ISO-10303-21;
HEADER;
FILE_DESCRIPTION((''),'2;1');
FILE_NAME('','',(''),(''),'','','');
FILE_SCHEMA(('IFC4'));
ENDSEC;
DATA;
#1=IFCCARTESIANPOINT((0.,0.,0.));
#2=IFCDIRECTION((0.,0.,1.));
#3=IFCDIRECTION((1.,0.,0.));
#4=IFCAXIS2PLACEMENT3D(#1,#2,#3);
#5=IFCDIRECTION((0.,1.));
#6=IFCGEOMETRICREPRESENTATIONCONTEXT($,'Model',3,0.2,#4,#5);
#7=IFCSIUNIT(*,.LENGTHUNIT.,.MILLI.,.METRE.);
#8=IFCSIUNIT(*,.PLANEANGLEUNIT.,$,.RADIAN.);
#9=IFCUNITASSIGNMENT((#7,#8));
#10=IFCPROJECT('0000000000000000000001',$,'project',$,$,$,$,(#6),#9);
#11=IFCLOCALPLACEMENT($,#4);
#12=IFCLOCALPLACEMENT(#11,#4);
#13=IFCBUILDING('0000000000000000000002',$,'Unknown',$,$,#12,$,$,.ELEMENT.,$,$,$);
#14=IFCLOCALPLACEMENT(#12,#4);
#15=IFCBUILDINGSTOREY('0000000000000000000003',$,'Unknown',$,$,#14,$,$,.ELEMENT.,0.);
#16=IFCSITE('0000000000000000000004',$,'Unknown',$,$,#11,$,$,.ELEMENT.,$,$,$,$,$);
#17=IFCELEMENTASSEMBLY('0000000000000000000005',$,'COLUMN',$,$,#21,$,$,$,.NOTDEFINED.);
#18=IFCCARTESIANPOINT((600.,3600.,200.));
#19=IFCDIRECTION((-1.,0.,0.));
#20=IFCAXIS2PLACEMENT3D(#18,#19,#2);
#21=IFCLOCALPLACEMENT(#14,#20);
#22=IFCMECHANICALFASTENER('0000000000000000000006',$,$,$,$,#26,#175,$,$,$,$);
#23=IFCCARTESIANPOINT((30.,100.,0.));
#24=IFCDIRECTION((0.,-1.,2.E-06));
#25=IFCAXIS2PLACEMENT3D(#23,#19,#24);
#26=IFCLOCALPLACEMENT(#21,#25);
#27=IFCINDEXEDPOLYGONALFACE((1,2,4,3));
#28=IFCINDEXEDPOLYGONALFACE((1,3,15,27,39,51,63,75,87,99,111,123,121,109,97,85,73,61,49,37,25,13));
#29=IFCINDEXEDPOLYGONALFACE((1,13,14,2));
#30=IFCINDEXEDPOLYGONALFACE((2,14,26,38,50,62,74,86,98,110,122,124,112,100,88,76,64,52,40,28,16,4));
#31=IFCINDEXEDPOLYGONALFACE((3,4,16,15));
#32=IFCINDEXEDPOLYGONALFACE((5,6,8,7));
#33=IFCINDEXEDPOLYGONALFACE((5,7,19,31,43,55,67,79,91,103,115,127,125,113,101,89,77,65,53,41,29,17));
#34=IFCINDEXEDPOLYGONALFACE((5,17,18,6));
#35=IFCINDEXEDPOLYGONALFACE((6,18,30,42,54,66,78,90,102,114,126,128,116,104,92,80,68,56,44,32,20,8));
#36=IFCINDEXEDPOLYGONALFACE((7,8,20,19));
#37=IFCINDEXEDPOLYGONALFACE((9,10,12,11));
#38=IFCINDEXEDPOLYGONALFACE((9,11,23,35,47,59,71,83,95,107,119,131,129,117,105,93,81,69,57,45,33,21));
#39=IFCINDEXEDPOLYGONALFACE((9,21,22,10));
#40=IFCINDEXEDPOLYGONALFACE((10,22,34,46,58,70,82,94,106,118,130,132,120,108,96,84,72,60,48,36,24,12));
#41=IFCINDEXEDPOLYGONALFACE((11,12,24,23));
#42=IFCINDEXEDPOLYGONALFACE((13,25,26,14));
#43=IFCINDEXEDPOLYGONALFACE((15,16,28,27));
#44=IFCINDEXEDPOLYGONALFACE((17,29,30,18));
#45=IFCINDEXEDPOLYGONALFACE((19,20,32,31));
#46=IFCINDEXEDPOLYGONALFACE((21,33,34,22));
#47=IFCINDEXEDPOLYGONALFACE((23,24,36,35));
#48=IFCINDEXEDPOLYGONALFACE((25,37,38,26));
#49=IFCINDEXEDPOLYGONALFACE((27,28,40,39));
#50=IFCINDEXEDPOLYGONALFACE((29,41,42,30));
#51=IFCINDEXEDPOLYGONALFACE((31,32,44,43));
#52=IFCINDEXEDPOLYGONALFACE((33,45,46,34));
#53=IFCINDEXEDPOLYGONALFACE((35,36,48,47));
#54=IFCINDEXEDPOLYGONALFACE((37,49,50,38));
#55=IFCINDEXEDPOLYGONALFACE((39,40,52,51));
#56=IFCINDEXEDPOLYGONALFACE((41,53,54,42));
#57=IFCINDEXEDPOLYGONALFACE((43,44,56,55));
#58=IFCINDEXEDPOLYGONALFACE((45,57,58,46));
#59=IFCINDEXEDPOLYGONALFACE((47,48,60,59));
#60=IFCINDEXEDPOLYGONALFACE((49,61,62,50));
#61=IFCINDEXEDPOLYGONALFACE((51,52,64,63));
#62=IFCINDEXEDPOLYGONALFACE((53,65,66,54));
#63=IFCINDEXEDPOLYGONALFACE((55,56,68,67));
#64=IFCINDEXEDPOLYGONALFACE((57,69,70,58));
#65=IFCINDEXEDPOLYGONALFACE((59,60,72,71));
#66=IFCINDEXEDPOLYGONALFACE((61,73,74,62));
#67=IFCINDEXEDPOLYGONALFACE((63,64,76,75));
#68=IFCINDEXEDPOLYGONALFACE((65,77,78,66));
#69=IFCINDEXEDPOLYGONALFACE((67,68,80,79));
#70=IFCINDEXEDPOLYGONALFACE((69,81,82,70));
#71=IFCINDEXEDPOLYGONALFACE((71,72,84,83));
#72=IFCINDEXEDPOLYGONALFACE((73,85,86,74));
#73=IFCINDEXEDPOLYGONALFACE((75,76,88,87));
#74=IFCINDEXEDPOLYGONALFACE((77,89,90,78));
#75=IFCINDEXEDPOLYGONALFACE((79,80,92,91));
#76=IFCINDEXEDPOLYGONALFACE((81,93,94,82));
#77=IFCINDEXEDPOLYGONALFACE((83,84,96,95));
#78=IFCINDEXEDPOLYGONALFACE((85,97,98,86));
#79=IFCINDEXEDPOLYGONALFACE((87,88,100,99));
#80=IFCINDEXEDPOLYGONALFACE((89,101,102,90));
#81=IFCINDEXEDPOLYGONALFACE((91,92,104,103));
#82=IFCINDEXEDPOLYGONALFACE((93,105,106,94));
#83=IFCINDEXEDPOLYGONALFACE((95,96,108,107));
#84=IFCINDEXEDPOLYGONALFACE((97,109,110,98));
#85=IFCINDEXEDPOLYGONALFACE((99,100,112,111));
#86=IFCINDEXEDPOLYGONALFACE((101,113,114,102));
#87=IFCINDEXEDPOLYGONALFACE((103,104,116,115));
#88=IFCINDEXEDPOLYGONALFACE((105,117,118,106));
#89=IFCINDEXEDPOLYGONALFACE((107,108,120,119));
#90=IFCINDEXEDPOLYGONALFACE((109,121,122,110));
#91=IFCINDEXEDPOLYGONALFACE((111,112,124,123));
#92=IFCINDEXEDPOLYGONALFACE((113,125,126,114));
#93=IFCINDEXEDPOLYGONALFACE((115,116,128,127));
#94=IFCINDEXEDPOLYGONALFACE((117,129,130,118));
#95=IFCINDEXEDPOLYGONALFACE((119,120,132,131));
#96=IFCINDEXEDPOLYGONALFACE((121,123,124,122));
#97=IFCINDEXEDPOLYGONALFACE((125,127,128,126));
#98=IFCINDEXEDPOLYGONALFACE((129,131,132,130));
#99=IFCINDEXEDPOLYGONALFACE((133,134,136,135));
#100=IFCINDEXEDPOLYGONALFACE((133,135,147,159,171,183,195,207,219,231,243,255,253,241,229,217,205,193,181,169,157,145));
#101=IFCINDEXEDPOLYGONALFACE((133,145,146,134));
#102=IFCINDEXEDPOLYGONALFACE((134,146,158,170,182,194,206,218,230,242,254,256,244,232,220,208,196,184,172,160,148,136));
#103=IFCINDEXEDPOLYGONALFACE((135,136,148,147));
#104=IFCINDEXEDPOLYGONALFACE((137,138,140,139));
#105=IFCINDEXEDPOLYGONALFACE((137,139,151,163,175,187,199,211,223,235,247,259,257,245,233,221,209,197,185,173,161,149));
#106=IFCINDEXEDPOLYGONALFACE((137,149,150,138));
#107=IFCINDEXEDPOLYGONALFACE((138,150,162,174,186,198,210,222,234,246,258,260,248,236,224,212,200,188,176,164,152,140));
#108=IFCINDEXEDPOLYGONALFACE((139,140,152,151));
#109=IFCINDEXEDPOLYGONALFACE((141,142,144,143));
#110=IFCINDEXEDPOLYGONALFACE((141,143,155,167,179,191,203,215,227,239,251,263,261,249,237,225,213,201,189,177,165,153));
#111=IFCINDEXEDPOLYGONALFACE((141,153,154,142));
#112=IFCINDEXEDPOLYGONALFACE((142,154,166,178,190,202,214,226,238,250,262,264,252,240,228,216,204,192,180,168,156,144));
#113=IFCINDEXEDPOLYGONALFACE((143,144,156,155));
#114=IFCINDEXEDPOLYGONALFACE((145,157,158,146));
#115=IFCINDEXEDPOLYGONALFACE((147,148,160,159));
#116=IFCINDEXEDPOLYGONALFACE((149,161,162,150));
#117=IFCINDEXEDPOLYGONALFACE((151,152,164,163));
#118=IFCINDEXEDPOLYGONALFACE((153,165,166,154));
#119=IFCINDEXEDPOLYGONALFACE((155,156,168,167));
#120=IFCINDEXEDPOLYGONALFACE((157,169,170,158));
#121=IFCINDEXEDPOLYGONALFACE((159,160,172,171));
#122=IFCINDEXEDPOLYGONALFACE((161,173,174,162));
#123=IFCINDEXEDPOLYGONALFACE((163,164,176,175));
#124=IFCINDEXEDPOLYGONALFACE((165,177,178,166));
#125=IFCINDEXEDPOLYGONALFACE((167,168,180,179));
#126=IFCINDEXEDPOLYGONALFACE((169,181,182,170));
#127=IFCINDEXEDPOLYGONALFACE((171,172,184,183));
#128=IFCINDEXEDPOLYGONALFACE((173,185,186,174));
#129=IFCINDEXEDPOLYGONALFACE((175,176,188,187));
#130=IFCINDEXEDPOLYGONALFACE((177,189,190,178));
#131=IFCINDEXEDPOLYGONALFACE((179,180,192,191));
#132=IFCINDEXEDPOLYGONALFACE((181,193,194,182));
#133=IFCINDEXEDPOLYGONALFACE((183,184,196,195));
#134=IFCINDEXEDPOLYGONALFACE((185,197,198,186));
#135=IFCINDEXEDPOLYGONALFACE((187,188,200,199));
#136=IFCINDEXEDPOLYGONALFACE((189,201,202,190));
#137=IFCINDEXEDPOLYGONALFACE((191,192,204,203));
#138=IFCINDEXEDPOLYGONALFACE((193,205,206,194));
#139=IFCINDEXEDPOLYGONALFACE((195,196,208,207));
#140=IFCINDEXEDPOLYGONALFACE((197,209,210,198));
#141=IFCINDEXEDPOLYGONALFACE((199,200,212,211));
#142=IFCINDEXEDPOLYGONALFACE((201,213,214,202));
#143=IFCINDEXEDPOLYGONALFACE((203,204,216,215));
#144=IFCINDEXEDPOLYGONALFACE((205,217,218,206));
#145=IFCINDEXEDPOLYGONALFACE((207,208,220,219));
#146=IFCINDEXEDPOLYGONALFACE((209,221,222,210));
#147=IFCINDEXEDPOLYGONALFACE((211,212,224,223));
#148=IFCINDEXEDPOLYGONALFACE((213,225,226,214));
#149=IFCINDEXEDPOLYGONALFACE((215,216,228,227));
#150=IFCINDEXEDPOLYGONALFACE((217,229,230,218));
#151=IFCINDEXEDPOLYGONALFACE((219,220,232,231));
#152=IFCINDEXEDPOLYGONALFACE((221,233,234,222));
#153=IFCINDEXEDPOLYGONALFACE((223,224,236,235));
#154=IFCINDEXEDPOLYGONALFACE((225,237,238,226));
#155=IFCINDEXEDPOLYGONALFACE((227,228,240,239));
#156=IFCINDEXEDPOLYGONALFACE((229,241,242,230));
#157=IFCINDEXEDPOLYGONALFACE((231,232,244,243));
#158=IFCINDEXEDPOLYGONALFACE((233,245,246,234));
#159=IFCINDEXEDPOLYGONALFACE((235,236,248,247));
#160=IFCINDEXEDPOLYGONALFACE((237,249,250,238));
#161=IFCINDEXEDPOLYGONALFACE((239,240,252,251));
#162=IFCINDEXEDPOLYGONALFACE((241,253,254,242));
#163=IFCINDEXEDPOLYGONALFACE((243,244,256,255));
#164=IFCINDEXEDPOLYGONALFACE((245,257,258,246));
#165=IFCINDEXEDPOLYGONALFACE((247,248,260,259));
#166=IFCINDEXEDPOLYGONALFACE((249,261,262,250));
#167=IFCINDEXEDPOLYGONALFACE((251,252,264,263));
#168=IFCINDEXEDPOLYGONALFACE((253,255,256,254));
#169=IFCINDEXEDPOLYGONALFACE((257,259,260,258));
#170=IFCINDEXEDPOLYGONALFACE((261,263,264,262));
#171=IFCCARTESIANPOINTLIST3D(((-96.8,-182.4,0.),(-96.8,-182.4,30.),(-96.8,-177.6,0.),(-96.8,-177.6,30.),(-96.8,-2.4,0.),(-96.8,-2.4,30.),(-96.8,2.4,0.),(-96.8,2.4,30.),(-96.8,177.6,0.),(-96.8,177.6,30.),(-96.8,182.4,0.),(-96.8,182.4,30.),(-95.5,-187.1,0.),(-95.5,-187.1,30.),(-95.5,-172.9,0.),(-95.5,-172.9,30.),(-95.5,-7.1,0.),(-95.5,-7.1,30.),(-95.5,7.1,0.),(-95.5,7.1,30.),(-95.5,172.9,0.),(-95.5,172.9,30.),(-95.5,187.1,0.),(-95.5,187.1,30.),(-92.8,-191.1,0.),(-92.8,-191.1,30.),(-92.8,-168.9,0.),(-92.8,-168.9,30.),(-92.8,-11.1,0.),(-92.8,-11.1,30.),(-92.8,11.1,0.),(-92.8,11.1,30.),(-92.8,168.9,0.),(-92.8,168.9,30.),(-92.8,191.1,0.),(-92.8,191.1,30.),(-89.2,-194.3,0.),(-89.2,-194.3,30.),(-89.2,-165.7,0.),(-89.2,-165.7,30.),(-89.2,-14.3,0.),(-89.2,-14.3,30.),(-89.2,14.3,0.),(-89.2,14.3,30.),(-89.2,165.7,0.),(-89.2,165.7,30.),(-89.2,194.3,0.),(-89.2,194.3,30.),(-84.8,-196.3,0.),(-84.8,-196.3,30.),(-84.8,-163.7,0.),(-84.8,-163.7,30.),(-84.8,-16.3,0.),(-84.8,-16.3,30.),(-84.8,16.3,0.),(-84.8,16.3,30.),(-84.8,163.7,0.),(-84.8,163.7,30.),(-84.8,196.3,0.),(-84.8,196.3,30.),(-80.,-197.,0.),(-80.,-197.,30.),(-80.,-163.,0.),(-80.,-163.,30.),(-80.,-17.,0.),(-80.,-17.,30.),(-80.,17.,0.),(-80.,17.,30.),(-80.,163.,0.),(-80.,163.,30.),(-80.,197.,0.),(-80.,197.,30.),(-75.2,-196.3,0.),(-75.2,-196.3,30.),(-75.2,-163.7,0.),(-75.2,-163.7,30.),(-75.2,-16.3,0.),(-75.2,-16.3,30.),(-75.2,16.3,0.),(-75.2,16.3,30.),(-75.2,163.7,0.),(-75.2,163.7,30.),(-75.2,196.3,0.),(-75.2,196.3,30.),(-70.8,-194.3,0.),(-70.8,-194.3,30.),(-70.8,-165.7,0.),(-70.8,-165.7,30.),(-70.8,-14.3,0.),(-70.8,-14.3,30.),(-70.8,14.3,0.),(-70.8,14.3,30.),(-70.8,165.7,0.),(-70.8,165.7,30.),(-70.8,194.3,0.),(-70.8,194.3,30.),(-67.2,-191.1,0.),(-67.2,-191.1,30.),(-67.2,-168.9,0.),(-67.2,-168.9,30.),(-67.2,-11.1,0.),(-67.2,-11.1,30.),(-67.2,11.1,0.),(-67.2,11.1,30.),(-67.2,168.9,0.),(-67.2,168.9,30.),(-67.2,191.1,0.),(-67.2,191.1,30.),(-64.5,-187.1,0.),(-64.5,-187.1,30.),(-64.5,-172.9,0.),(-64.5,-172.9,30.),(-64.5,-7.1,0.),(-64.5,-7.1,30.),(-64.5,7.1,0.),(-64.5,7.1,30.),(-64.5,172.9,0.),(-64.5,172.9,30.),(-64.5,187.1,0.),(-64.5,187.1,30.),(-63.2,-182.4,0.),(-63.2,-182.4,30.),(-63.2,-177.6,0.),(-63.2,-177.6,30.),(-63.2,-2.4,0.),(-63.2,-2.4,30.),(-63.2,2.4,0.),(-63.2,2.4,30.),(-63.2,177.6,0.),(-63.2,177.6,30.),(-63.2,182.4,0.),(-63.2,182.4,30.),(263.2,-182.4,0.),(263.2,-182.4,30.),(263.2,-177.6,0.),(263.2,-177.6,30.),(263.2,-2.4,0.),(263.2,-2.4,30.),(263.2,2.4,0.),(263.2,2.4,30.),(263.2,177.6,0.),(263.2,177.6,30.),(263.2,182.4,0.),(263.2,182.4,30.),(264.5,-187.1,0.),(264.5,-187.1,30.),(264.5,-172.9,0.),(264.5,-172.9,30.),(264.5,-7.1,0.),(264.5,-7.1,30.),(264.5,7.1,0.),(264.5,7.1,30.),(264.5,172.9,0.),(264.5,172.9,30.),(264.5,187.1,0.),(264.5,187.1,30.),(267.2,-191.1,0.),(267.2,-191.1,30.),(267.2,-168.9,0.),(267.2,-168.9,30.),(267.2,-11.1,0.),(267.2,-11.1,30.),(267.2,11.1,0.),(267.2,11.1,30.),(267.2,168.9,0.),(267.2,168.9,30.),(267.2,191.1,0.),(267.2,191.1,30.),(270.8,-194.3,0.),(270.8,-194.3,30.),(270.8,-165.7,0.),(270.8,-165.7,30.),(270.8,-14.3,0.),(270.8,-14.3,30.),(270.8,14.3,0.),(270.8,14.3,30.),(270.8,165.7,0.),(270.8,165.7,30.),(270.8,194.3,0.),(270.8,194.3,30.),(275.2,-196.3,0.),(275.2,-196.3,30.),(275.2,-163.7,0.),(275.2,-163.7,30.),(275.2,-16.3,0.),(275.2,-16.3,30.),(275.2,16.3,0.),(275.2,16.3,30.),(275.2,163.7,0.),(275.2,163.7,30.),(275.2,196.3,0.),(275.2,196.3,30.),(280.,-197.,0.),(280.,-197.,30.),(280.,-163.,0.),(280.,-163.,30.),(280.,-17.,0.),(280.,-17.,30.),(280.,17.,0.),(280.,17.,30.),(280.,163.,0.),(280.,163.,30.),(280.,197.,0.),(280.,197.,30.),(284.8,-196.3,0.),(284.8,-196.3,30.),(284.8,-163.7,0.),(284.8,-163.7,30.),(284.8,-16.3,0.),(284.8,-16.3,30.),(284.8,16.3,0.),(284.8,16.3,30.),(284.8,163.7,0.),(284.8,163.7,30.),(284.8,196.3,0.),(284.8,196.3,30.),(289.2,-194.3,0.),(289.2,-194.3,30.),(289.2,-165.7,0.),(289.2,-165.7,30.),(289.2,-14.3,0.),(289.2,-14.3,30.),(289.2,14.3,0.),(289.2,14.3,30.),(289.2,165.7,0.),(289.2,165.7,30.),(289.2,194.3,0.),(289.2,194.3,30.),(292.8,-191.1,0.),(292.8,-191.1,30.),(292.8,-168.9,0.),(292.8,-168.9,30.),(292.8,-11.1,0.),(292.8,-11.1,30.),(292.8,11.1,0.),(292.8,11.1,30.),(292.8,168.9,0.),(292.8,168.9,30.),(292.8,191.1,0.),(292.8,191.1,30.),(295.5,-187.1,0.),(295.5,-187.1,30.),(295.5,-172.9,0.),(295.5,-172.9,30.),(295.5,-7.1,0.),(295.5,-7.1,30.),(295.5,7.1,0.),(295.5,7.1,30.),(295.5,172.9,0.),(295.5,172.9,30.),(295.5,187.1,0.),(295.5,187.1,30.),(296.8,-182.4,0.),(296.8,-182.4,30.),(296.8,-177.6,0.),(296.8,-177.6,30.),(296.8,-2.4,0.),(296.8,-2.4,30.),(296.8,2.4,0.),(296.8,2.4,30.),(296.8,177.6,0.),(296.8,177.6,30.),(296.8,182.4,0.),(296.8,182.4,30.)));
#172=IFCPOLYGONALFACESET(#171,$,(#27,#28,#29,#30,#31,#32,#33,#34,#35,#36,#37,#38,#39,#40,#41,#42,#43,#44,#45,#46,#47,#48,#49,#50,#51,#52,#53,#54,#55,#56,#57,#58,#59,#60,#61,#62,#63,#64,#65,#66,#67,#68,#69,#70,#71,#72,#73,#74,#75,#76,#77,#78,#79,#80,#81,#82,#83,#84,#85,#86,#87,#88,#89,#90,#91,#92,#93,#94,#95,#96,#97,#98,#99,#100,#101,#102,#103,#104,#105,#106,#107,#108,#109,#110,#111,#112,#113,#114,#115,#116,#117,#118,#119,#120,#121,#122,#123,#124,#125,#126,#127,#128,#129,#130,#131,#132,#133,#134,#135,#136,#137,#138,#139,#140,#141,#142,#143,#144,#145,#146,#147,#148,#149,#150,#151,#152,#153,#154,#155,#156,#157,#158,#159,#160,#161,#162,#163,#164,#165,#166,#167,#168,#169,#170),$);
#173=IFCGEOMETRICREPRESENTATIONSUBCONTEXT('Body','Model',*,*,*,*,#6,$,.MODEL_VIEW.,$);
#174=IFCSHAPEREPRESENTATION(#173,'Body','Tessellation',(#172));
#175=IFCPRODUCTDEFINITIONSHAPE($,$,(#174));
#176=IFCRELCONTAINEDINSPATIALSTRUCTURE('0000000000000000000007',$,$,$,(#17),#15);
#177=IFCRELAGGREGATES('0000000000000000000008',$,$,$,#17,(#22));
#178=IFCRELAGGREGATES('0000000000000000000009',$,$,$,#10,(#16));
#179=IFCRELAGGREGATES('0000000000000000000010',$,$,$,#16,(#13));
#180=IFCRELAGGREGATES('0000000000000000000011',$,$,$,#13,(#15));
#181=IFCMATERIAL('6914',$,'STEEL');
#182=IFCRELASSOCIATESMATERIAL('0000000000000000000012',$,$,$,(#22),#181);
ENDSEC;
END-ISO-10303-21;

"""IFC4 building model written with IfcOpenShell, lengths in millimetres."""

from ifc_helpers import new_model, si_unit, direction, frame, origin_with_axes, place, context, subcontext, project, spatial, arc, indexed_curve, outline, extrude, source, transform, mapped, material, element, aggregate, save


model = new_model("IFC4")

# Units and contexts
model_context = context("Model", 3, precision=0.2, world=origin_with_axes(), true_north=direction((0.0, 1.0)))
body_context = subcontext(model_context, "Body", "Model", "MODEL_VIEW")
ifc_project = project(units=[si_unit("LENGTHUNIT", "METRE", prefix="MILLI"), si_unit("PLANEANGLEUNIT", "RADIAN")], contexts=[model_context])

# Site, building, storey
site_placement = place(None, origin_with_axes())
site = spatial("IfcSite", under=ifc_project, at=site_placement, Name="Unknown", CompositionType="ELEMENT")
building_placement = place(site_placement, origin_with_axes())
building = spatial("IfcBuilding", under=site, at=building_placement, Name="Unknown", CompositionType="ELEMENT")
storey_placement = place(building_placement, origin_with_axes())
storey = spatial("IfcBuildingStorey", under=building, at=storey_placement, Name="Unknown", CompositionType="ELEMENT", Elevation=0.0)

# Element assembly
assembly_1_placement = place(storey_placement, frame((600.0, 3600.0, 200.0), z_axis=(-1.0, 0.0, 0.0), x_axis=(0.0, 0.0, 1.0)))
assembly_1 = element("IfcElementAssembly", 1, at=assembly_1_placement, inside=storey, Name="COLUMN", PredefinedType="NOTDEFINED")

# Shared definitions
ifc_material_1 = material(Name="6914", Category="STEEL")

# Mechanical fastener
shared_shape_1 = source(origin_with_axes(), body_context, "Body", "SweptSolid", [
    extrude(outline(indexed_curve([(17.0, 0.0), (0.0, 17.0), (-17.0, 0.0), (0.0, -17.0)], segments=[arc(1, 2, 3), arc(3, 4, 1)])), frame((0.0, 0.0, 30.0), z_axis=(0.0, -0.000002, -1.0), x_axis=(0.0, 1.0, 0.0)), (0.0, 0.0, 1.0), 30.0),
])
mechanical_fastener_1_placement = place(assembly_1_placement, frame((30.0, 100.0, 0.0), z_axis=(-1.0, 0.0, 0.0), x_axis=(0.0, -1.0, 0.000002)))
mechanical_fastener_1 = element("IfcMechanicalFastener", 2, at=mechanical_fastener_1_placement, material=ifc_material_1, context=body_context, shape_type="MappedRepresentation", body=[
    mapped(shared_shape_1, transform((-80.0, -180.0, 0.0))),
    mapped(shared_shape_1, transform((-80.0, 0.0, 0.0))),
    mapped(shared_shape_1, transform((-80.0, 180.0, 0.0))),
    mapped(shared_shape_1, transform((280.0, -180.0, 0.0))),
    mapped(shared_shape_1, transform((280.0, 0.0, 0.0))),
    mapped(shared_shape_1, transform((280.0, 180.0, 0.0))),
])
aggregate(assembly_1, [mechanical_fastener_1])

save(model, "model.ifc")
